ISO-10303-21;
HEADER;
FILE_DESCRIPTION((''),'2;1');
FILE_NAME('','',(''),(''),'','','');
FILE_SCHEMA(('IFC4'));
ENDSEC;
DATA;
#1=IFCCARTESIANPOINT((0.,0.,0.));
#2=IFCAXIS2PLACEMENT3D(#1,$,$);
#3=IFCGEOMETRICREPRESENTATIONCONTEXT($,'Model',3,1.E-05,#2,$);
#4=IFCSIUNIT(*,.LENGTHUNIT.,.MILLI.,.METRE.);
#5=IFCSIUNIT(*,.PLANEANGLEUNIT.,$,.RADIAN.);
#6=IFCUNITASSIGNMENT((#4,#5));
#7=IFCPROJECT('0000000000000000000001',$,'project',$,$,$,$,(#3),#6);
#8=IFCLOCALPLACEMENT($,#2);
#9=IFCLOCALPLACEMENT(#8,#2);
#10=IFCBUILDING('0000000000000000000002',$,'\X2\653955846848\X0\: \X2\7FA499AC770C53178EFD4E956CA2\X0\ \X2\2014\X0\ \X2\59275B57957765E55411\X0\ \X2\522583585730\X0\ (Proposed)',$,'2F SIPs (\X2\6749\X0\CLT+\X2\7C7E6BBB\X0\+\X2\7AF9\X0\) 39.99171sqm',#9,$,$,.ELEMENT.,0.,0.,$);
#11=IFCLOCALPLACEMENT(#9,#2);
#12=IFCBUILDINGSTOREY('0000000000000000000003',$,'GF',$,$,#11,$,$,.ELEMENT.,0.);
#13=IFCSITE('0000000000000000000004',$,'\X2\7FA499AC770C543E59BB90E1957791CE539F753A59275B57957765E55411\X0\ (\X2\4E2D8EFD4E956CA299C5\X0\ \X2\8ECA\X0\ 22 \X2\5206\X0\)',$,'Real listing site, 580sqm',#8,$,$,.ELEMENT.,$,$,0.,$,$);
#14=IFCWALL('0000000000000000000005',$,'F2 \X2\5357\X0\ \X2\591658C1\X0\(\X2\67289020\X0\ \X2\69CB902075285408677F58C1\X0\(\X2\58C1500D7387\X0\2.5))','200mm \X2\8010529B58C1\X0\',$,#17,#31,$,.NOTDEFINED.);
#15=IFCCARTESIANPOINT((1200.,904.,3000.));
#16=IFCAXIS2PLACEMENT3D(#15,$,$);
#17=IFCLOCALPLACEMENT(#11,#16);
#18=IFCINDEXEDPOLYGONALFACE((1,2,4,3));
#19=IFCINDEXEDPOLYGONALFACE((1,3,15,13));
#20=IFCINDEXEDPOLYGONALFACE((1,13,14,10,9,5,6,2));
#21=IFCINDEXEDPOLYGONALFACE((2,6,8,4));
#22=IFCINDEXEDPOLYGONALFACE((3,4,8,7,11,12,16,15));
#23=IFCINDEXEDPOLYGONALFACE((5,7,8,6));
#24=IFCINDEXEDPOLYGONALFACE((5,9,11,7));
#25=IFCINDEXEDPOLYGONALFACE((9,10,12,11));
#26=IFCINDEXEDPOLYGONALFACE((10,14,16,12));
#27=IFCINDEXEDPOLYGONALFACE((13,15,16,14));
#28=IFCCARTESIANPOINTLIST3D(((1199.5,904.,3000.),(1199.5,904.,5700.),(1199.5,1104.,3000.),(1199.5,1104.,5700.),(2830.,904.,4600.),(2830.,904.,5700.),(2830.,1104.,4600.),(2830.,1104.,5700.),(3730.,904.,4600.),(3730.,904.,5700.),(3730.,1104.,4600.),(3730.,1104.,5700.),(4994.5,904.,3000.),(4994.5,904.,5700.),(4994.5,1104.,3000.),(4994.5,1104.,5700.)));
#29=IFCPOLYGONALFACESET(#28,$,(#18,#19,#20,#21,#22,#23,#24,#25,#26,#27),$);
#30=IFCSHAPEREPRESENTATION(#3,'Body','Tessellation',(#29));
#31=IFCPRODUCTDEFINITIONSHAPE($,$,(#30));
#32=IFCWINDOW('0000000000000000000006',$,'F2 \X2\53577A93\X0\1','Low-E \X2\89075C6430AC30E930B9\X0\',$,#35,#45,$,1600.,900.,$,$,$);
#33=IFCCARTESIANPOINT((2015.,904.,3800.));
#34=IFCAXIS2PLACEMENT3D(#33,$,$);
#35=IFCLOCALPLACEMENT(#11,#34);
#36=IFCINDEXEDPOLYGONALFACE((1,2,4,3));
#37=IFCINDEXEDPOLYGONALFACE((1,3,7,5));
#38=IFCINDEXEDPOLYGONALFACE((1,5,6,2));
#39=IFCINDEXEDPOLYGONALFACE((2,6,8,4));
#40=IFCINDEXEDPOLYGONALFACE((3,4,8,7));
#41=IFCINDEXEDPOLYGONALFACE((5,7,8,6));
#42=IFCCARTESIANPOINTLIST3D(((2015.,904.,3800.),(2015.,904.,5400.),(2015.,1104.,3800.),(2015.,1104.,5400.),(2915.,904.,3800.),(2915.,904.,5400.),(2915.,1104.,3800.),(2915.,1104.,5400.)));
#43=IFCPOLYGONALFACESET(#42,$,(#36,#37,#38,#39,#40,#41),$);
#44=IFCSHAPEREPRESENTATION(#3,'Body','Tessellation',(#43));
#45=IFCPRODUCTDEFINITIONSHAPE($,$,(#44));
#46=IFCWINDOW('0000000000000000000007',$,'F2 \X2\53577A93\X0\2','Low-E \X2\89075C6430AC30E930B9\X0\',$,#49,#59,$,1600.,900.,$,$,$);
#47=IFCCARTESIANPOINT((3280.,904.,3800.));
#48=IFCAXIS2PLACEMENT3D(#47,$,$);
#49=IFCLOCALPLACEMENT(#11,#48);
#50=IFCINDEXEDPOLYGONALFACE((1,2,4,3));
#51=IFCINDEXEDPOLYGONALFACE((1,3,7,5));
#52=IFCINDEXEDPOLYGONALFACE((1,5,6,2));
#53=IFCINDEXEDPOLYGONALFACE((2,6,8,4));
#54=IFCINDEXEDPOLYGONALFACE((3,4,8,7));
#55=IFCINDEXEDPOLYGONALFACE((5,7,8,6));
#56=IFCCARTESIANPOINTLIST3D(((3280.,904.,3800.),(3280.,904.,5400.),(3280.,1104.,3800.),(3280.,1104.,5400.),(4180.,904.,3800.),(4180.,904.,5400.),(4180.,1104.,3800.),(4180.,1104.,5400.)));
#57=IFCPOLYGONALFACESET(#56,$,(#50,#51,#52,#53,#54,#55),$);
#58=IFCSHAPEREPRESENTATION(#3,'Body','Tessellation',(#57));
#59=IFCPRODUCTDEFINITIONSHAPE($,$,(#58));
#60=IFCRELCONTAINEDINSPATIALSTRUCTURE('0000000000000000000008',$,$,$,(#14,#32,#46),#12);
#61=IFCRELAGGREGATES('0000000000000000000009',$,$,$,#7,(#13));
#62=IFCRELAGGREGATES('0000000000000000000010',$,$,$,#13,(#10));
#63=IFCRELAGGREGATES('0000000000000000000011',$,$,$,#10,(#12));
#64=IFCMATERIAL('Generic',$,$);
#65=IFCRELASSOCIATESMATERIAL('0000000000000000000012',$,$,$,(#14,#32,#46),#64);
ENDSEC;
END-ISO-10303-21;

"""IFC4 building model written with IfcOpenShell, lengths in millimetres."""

from ifc_helpers import new_model, si_unit, frame, frame_2d, origin, place, context, project, spatial, rectangle, extrude, material, element, fill, save


model = new_model("IFC4")

# Units and contexts
model_context = context("Model", 3, precision=1e-05, world=origin())
ifc_project = project(units=[si_unit("LENGTHUNIT", "METRE", prefix="MILLI"), si_unit("PLANEANGLEUNIT", "RADIAN")], contexts=[model_context])

# Site, building, storey
site_placement = place(None, origin())
site = spatial("IfcSite", under=ifc_project, at=site_placement, Name="群馬県吾妻郡長野原町大字長日向 (中軽井沢駅 車 22 分)", ObjectType="Real listing site, 580sqm", CompositionType="ELEMENT", RefElevation=0.0)
building_placement = place(site_placement, origin())
building = spatial("IfcBuilding", under=site, at=building_placement, Name="改善案: 群馬県北軽井沢 — 大字長日向 別荘地 (Proposed)", ObjectType="2F SIPs (杉CLT+籾殻+竹) 39.99171sqm", CompositionType="ELEMENT", ElevationOfRefHeight=0.0, ElevationOfTerrain=0.0)
storey_placement = place(building_placement, origin())
storey = spatial("IfcBuildingStorey", under=building, at=storey_placement, Name="GF", CompositionType="ELEMENT", Elevation=0.0)

# Shared definitions
ifc_material_1 = material(Name="Generic")

# Wall, openings, windows
wall_1_placement = place(storey_placement, frame((1200.0, 904.0, 3000.0)))
wall_1 = element("IfcWall", 1, at=wall_1_placement, inside=storey, material=ifc_material_1, Name="F2 南 外壁(木造 構造用合板壁(壁倍率2.5))", Description="200mm 耐力壁", PredefinedType="NOTDEFINED", context=model_context, shape_type="SweptSolid", body=[
    extrude(rectangle(XDim=3795.0, YDim=200.0, at=frame_2d((1897.0, 100.0))), frame((1200.0, 904.0, 3000.0)), (0.0, 0.0, 1.0), 2700.0),
])
opening_1_placement = place(storey_placement, frame((2015.0, 904.0, 3800.0)))
opening_1 = element("IfcOpeningElement", 2, at=opening_1_placement, cuts=wall_1, PredefinedType="NOTDEFINED", context=model_context, shape_type="SweptSolid", body=[
    extrude(rectangle(XDim=900.0, YDim=200.0, at=frame_2d((450.0, 100.0))), frame((2015.0, 904.0, 3800.0)), (0.0, 0.0, 1.0), 1600.0),
])
opening_2_placement = place(storey_placement, frame((3280.0, 904.0, 3800.0)))
opening_2 = element("IfcOpeningElement", 3, at=opening_2_placement, cuts=wall_1, PredefinedType="NOTDEFINED", context=model_context, shape_type="SweptSolid", body=[
    extrude(rectangle(XDim=900.0, YDim=200.0, at=frame_2d((450.0, 100.0))), frame((3280.0, 904.0, 3800.0)), (0.0, 0.0, 1.0), 1600.0),
])
window_1_placement = place(storey_placement, frame((2015.0, 904.0, 3800.0)))
window_1 = element("IfcWindow", 4, at=window_1_placement, inside=storey, material=ifc_material_1, Name="F2 南窓1", Description="Low-E 複層ガラス", OverallHeight=1600.0, OverallWidth=900.0, context=model_context, shape_type="SweptSolid", body=[
    extrude(rectangle(XDim=900.0, YDim=200.0, at=frame_2d((450.0, 100.0))), frame((2015.0, 904.0, 3800.0)), (0.0, 0.0, 1.0), 1600.0),
])
fill(opening_1, window_1)
window_2_placement = place(storey_placement, frame((3280.0, 904.0, 3800.0)))
window_2 = element("IfcWindow", 5, at=window_2_placement, inside=storey, material=ifc_material_1, Name="F2 南窓2", Description="Low-E 複層ガラス", OverallHeight=1600.0, OverallWidth=900.0, context=model_context, shape_type="SweptSolid", body=[
    extrude(rectangle(XDim=900.0, YDim=200.0, at=frame_2d((450.0, 100.0))), frame((3280.0, 904.0, 3800.0)), (0.0, 0.0, 1.0), 1600.0),
])
fill(opening_2, window_2)

save(model, "model.ifc")
